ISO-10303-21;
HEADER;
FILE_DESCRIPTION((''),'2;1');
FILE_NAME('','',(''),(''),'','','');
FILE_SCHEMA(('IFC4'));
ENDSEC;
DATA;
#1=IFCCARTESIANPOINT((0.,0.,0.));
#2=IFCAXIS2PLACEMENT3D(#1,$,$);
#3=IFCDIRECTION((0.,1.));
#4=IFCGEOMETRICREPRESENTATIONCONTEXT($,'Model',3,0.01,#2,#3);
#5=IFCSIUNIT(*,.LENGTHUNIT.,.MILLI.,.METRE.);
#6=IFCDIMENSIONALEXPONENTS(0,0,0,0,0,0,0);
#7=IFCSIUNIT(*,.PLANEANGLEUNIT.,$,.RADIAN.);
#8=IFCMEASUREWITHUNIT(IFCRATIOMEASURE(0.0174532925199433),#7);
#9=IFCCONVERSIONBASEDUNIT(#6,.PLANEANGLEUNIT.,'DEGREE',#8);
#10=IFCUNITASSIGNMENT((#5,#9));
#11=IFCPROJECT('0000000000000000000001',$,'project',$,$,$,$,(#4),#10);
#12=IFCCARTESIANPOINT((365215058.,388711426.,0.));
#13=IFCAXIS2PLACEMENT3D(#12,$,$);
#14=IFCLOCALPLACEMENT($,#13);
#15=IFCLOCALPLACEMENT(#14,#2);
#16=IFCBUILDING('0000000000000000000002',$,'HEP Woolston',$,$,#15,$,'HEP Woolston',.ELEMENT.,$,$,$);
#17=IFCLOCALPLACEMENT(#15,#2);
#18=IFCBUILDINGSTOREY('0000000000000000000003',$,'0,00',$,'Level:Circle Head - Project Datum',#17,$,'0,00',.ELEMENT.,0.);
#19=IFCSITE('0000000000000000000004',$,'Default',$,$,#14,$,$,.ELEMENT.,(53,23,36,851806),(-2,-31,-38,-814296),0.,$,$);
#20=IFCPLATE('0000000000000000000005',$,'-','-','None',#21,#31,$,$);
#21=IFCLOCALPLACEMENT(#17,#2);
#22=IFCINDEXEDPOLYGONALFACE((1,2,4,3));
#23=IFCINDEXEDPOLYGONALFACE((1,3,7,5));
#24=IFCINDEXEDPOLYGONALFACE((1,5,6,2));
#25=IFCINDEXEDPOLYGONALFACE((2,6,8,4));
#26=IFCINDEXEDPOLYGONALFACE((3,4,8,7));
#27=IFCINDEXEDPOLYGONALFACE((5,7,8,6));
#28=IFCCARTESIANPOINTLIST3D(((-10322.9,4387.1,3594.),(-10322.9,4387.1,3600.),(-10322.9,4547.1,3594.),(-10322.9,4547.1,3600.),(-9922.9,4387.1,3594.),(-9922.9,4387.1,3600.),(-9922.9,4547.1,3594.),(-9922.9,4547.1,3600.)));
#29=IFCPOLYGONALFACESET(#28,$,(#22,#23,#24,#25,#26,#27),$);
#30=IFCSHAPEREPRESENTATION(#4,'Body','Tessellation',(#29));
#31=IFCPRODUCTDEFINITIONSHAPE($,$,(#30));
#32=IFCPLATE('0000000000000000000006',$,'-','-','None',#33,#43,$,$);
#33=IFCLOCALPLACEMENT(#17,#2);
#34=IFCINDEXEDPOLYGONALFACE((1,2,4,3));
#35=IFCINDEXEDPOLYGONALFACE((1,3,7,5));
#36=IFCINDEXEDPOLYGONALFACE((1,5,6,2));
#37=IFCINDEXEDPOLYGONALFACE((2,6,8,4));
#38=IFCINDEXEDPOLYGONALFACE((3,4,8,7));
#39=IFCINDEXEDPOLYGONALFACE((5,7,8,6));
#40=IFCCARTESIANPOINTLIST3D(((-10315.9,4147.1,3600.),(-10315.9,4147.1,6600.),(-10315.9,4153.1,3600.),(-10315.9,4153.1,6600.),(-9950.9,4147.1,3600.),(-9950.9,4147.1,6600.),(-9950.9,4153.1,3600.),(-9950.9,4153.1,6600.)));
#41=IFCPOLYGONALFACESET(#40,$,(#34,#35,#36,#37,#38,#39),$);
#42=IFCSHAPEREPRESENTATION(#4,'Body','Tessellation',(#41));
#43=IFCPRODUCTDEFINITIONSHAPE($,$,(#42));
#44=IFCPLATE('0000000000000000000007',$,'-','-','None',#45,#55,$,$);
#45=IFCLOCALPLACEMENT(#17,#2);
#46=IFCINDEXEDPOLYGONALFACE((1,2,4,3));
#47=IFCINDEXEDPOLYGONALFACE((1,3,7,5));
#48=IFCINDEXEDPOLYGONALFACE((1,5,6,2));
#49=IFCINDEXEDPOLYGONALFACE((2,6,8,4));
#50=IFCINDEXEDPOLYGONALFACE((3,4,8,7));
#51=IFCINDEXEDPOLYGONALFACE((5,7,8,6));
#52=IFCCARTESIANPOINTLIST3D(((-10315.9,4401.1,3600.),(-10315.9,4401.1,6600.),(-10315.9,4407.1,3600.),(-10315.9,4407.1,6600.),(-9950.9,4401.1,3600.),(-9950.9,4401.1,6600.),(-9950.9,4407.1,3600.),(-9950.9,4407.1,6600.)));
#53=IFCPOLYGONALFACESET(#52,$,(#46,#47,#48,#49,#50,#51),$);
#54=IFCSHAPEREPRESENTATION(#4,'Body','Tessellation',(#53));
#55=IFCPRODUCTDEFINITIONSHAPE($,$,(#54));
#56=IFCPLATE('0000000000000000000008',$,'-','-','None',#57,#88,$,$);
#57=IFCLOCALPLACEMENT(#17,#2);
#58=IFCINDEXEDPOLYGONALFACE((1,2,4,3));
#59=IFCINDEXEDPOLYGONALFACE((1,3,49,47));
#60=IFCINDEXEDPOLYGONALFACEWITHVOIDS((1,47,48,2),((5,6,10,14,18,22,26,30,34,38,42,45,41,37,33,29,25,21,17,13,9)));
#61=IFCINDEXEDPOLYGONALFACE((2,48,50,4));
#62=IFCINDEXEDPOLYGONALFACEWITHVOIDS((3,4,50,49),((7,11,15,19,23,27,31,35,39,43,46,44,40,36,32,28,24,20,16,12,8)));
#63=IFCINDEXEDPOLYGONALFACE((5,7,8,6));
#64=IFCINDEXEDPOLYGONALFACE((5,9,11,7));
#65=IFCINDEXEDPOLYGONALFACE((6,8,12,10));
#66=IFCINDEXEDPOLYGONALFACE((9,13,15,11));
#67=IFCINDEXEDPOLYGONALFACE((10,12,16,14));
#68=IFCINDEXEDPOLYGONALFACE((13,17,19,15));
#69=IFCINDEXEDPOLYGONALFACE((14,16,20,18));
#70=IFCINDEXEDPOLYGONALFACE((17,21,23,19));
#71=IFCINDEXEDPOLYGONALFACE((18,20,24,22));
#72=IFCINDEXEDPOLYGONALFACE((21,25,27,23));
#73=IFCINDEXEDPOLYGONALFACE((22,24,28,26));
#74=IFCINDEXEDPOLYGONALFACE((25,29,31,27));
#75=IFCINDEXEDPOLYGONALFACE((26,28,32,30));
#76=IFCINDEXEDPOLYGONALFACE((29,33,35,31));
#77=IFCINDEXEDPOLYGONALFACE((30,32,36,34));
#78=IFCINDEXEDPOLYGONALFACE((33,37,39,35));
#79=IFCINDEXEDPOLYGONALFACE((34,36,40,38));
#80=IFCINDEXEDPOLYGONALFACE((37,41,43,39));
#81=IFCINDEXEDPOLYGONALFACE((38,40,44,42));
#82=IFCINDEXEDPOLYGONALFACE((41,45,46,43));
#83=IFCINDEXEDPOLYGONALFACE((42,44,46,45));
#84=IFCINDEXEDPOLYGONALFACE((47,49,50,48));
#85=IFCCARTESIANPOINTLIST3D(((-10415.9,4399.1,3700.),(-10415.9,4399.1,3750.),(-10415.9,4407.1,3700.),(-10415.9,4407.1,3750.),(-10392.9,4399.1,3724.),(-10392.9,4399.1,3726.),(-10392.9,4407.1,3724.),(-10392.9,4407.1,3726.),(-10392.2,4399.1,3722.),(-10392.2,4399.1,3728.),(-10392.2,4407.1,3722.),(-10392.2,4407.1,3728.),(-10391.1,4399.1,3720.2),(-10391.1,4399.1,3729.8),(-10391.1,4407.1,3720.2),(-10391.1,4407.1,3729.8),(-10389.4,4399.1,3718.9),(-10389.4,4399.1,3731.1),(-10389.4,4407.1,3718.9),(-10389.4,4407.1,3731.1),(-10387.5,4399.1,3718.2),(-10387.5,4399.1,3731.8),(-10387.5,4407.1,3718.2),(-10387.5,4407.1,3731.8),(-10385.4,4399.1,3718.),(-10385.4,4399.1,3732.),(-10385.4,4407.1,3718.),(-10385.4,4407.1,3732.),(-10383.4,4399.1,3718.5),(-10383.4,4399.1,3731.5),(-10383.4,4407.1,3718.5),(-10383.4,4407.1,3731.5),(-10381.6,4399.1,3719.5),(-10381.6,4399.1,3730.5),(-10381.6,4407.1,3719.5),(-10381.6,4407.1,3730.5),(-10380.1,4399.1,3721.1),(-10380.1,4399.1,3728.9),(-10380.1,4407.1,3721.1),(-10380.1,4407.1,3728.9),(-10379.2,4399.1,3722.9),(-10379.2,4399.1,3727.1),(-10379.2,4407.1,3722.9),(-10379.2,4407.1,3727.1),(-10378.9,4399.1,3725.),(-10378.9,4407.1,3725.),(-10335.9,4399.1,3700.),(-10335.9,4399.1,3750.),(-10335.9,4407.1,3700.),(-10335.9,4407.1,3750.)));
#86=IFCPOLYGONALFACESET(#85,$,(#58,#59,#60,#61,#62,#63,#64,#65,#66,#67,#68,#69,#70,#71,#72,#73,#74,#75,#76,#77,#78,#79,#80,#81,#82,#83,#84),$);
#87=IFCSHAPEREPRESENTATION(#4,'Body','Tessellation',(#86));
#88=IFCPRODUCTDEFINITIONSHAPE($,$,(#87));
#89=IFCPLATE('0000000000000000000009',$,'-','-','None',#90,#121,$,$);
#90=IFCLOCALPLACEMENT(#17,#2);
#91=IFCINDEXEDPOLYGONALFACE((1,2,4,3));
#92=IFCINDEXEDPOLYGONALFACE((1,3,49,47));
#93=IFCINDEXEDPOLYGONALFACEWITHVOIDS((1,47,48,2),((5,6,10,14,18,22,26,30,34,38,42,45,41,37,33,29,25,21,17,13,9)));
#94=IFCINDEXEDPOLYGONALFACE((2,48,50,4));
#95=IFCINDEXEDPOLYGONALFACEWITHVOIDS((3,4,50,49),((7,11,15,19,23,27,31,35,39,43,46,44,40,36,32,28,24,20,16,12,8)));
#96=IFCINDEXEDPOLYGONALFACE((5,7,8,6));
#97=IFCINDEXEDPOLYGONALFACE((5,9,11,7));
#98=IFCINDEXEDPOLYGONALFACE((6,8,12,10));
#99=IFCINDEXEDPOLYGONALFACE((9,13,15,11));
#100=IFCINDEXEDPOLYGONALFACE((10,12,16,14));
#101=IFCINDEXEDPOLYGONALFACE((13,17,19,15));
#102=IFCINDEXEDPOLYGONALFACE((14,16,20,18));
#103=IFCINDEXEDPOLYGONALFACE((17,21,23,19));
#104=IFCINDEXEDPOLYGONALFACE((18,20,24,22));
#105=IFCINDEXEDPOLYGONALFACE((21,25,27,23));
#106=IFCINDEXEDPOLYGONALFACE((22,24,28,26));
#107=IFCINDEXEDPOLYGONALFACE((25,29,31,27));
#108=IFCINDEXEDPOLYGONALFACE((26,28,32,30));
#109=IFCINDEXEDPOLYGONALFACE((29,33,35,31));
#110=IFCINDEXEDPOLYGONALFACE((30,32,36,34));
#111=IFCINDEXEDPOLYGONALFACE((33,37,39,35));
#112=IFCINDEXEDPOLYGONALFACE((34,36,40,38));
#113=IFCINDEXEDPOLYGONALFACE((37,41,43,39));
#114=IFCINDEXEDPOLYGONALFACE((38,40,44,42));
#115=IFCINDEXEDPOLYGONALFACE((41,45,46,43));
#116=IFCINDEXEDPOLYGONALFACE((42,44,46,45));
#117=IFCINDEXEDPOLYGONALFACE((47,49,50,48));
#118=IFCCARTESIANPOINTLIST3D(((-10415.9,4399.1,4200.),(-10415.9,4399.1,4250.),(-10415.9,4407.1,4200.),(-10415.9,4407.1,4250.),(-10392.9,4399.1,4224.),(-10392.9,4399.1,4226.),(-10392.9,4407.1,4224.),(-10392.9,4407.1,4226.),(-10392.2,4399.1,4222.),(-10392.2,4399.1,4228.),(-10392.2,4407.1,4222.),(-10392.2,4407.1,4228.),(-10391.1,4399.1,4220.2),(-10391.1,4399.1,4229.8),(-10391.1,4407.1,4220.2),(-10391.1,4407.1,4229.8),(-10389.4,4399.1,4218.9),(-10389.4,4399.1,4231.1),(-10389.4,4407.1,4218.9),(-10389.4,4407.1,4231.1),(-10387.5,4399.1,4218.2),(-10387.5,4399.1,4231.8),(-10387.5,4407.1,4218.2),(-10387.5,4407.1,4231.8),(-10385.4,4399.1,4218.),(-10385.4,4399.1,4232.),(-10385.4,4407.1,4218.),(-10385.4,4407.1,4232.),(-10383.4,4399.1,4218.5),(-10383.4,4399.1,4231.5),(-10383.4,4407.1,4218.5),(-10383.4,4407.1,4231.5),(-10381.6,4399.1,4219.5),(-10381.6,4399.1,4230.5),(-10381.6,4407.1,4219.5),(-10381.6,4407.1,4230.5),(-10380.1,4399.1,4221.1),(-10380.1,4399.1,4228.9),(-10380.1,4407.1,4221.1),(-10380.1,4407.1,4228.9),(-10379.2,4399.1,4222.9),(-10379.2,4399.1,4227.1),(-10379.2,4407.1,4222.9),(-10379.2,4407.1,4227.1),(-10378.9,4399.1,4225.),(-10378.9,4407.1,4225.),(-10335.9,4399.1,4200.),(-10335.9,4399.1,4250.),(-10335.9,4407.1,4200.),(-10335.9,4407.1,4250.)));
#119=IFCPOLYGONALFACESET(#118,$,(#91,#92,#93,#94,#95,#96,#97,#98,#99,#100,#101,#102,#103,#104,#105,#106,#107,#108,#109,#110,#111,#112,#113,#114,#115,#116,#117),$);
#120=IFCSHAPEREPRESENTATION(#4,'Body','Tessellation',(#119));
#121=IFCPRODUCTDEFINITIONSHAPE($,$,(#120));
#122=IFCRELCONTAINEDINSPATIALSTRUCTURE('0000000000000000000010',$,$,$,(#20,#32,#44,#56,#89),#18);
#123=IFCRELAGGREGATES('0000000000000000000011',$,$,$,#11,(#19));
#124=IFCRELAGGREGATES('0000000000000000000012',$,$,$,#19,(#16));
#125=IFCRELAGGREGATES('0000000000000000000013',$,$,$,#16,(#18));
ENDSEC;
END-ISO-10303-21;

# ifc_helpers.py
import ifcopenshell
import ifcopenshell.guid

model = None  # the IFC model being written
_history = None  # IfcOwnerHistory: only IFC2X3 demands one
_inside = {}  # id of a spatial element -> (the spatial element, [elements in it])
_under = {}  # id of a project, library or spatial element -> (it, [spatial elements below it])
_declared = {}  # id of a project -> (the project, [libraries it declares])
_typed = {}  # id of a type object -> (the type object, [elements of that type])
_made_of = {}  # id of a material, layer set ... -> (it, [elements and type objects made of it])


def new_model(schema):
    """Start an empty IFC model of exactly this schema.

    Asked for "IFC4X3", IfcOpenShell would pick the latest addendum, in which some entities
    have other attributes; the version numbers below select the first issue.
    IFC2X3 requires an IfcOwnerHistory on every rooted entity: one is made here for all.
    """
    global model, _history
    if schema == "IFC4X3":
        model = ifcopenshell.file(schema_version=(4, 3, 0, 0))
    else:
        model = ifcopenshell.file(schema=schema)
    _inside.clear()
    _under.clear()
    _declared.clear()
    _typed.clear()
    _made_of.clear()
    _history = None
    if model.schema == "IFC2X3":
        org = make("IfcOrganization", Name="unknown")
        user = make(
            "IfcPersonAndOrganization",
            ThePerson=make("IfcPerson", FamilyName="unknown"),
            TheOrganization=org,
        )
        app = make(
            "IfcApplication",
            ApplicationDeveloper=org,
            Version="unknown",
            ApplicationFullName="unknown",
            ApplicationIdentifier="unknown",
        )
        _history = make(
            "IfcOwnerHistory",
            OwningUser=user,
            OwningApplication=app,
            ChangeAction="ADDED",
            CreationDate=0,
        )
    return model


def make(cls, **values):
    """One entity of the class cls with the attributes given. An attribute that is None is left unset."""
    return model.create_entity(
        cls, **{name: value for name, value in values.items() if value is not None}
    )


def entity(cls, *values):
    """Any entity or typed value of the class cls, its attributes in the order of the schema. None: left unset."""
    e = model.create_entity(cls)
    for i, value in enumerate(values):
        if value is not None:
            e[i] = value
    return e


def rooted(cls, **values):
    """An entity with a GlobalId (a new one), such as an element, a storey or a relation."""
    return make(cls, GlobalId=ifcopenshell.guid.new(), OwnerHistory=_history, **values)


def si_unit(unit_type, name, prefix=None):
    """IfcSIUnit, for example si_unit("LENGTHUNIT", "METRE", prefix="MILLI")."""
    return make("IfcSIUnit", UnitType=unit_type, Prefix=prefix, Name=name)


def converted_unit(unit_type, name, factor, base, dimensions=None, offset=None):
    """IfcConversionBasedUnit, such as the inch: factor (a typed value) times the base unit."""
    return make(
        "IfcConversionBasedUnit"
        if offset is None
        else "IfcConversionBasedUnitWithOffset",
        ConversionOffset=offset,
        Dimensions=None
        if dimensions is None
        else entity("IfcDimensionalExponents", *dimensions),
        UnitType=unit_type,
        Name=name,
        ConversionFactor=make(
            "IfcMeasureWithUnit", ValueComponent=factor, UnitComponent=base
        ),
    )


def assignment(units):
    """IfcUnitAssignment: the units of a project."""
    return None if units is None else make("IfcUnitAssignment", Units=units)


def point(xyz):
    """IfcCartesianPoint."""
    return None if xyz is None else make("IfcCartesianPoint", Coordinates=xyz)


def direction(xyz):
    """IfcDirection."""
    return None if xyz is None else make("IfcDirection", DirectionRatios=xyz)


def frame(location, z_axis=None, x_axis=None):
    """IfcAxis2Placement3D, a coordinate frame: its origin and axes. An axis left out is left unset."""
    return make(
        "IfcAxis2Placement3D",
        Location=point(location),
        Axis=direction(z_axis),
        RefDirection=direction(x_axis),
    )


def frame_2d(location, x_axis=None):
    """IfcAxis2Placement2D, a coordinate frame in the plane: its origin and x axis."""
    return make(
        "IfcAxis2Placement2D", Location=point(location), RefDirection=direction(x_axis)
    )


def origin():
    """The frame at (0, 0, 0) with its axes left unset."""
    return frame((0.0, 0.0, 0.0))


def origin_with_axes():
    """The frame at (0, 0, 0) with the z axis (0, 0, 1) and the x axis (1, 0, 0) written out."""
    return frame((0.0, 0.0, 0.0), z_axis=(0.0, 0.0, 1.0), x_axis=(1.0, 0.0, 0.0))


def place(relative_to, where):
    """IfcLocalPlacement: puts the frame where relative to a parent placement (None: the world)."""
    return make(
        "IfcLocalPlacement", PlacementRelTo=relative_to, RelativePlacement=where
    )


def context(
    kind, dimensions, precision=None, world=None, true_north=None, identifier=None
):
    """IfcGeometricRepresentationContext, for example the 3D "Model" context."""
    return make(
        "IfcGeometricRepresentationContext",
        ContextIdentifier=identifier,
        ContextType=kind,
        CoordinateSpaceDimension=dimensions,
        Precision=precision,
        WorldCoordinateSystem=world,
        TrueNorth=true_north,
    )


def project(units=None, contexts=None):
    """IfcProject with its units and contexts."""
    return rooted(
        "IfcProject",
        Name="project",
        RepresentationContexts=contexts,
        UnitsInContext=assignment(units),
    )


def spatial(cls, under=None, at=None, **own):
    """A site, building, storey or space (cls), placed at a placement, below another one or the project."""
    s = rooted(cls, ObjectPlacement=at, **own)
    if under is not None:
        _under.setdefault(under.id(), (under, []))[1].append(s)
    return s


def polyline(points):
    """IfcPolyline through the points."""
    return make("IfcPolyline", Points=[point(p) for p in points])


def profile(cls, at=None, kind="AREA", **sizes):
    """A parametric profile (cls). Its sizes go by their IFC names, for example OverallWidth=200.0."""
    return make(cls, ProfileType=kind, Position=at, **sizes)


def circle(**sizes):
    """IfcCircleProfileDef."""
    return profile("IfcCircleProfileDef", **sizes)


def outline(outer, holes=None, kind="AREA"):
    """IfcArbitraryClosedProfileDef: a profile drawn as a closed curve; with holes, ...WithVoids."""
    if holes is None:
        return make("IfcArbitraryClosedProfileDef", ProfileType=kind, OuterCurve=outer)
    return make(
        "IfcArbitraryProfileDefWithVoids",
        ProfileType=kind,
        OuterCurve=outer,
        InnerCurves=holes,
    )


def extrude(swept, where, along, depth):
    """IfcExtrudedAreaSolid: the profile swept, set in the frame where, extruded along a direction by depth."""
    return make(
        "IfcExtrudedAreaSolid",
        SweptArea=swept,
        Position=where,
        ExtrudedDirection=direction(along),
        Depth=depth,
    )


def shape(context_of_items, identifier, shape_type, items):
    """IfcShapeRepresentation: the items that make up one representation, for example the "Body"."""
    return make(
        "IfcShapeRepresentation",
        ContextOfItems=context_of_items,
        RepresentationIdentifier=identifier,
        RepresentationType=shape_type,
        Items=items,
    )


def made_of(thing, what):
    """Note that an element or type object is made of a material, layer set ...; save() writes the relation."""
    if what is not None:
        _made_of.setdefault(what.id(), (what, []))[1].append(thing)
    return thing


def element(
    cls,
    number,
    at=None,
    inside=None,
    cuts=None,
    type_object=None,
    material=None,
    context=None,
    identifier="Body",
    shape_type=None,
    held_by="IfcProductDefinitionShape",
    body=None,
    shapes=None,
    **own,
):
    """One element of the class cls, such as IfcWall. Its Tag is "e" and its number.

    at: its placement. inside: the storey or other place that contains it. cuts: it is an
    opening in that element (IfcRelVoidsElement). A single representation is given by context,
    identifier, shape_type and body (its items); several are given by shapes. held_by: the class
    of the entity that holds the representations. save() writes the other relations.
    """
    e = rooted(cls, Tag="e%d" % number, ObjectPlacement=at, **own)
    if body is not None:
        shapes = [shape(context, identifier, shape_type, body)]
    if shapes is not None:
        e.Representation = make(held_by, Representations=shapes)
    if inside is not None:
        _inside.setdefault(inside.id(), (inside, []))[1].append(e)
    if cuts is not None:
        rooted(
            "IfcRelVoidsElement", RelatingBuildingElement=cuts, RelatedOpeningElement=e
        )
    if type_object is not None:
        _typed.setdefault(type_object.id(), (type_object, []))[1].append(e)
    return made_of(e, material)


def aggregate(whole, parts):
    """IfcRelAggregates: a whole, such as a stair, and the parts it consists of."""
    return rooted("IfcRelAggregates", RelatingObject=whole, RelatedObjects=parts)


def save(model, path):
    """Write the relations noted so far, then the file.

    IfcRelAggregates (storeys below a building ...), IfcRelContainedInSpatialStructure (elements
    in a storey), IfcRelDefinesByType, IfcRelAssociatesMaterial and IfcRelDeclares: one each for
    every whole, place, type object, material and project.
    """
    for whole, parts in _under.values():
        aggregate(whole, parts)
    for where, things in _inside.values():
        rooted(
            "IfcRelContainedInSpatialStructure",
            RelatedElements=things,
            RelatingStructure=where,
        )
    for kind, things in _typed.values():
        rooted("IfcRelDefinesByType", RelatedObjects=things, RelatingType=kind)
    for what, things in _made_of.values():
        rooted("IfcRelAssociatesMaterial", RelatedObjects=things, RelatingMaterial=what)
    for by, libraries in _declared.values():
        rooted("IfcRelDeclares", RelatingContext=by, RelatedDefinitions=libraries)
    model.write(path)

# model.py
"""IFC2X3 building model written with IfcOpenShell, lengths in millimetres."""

from ifc_helpers import new_model, entity, si_unit, converted_unit, direction, frame, frame_2d, origin, origin_with_axes, place, context, project, spatial, polyline, circle, outline, extrude, element, save


model = new_model("IFC2X3")

# Units and contexts
model_context = context("Model", 3, precision=0.01, world=origin(), true_north=direction((0.0, 1.0)))
ifc_project = project(units=[si_unit("LENGTHUNIT", "METRE", prefix="MILLI"), converted_unit("PLANEANGLEUNIT", "DEGREE", entity("IfcRatioMeasure", 0.0174532925199433), si_unit("PLANEANGLEUNIT", "RADIAN"), dimensions=[0, 0, 0, 0, 0, 0, 0])], contexts=[model_context])

# Site, building, storey
site_placement = place(None, frame((365215058.0, 388711426.0, 0.0)))
site = spatial("IfcSite", under=ifc_project, at=site_placement, Name="Default", CompositionType="ELEMENT", RefLatitude=(53, 23, 36, 851806), RefLongitude=(-2, -31, -38, -814296), RefElevation=0.0)
building_placement = place(site_placement, origin())
building = spatial("IfcBuilding", under=site, at=building_placement, Name="HEP Woolston", LongName="HEP Woolston", CompositionType="ELEMENT")
storey_placement = place(building_placement, origin())
storey = spatial("IfcBuildingStorey", under=building, at=storey_placement, Name="0,00", ObjectType="Level:Circle Head - Project Datum", LongName="0,00", CompositionType="ELEMENT", Elevation=0.0)

# Plates
plate_1_placement = place(storey_placement, frame((-10322.9, 4387.1, 3594.0)))
element("IfcPlate", 1, at=plate_1_placement, inside=storey, Name="-", Description="-", ObjectType="None", context=model_context, shape_type="SweptSolid", body=[
    extrude(outline(polyline([(0.0, 0.0), (400.0, 0.0), (400.0, 160.0), (0.0, 160.0), (0.0, 0.0)])), origin_with_axes(), (0.0, 0.0, 1.0), 6.0),
])
for number, where, z_axis, x_axis, name in (
    (2, (-10315.9, 4153.1, 6600.0), (0.0, -1.0, 0.0), (1.0, 0.0, 0.0), "-"),
    (3, (-10315.9, 4407.1, 6600.0), (0.0, -1.0, 0.0), (1.0, 0.0, 0.0), "-"),
):
    element("IfcPlate", number, at=place(storey_placement, frame(where, z_axis=z_axis, x_axis=x_axis)), inside=storey, Name=name, Description="-", ObjectType="None", context=model_context, shape_type="SweptSolid", body=[
        extrude(outline(polyline([(0.0, 0.0), (0.0, -3000.0), (365.0, -3000.0), (365.0, 0.0), (0.0, 0.0)])), origin_with_axes(), (0.0, 0.0, 1.0), 6.0),
    ])

# Plates, openings
plate_2_placement = place(storey_placement, frame((-10335.9, 4407.1, 3750.0), z_axis=(0.0, 1.0, 0.0), x_axis=(-1.0, 0.0, 0.0)))
plate_2 = element("IfcPlate", 4, at=plate_2_placement, inside=storey, Name="-", Description="-", ObjectType="None", context=model_context, shape_type="SweptSolid", body=[
    extrude(outline(polyline([(0.0, 0.0), (0.0, -50.0), (80.0, -50.0), (80.0, 0.0), (0.0, 0.0)])), origin_with_axes(), (0.0, 0.0, -1.0), 8.0),
])
opening_1_placement = place(plate_2_placement, frame((57.0, -25.0, -8.5), z_axis=(0.0, 0.0, -1.0), x_axis=(-1.0, 0.0, 0.0)))
element("IfcOpeningElement", 5, at=opening_1_placement, cuts=plate_2, ObjectType="Opening", context=model_context, shape_type="SweptSolid", body=[
    extrude(circle(Radius=7.0, at=frame_2d((7.0, 0.0), x_axis=(1.0, 0.0))), origin(), (0.0, 0.0, -1.0), 9.0),
])
plate_3_placement = place(storey_placement, frame((-10335.9, 4407.1, 4250.0), z_axis=(0.0, 1.0, 0.0), x_axis=(-1.0, 0.0, 0.0)))
plate_3 = element("IfcPlate", 6, at=plate_3_placement, inside=storey, Name="-", Description="-", ObjectType="None", context=model_context, shape_type="SweptSolid", body=[
    extrude(outline(polyline([(0.0, 0.0), (0.0, -50.0), (80.0, -50.0), (80.0, 0.0), (0.0, 0.0)])), origin_with_axes(), (0.0, 0.0, -1.0), 8.0),
])
opening_2_placement = place(plate_3_placement, frame((57.0, -25.0, -8.5), z_axis=(0.0, 0.0, -1.0), x_axis=(-1.0, 0.0, 0.0)))
element("IfcOpeningElement", 7, at=opening_2_placement, cuts=plate_3, ObjectType="Opening", context=model_context, shape_type="SweptSolid", body=[
    extrude(circle(Radius=7.0, at=frame_2d((7.0, 0.0), x_axis=(1.0, 0.0))), origin(), (0.0, 0.0, -1.0), 9.0),
])

save(model, "model.ifc")
